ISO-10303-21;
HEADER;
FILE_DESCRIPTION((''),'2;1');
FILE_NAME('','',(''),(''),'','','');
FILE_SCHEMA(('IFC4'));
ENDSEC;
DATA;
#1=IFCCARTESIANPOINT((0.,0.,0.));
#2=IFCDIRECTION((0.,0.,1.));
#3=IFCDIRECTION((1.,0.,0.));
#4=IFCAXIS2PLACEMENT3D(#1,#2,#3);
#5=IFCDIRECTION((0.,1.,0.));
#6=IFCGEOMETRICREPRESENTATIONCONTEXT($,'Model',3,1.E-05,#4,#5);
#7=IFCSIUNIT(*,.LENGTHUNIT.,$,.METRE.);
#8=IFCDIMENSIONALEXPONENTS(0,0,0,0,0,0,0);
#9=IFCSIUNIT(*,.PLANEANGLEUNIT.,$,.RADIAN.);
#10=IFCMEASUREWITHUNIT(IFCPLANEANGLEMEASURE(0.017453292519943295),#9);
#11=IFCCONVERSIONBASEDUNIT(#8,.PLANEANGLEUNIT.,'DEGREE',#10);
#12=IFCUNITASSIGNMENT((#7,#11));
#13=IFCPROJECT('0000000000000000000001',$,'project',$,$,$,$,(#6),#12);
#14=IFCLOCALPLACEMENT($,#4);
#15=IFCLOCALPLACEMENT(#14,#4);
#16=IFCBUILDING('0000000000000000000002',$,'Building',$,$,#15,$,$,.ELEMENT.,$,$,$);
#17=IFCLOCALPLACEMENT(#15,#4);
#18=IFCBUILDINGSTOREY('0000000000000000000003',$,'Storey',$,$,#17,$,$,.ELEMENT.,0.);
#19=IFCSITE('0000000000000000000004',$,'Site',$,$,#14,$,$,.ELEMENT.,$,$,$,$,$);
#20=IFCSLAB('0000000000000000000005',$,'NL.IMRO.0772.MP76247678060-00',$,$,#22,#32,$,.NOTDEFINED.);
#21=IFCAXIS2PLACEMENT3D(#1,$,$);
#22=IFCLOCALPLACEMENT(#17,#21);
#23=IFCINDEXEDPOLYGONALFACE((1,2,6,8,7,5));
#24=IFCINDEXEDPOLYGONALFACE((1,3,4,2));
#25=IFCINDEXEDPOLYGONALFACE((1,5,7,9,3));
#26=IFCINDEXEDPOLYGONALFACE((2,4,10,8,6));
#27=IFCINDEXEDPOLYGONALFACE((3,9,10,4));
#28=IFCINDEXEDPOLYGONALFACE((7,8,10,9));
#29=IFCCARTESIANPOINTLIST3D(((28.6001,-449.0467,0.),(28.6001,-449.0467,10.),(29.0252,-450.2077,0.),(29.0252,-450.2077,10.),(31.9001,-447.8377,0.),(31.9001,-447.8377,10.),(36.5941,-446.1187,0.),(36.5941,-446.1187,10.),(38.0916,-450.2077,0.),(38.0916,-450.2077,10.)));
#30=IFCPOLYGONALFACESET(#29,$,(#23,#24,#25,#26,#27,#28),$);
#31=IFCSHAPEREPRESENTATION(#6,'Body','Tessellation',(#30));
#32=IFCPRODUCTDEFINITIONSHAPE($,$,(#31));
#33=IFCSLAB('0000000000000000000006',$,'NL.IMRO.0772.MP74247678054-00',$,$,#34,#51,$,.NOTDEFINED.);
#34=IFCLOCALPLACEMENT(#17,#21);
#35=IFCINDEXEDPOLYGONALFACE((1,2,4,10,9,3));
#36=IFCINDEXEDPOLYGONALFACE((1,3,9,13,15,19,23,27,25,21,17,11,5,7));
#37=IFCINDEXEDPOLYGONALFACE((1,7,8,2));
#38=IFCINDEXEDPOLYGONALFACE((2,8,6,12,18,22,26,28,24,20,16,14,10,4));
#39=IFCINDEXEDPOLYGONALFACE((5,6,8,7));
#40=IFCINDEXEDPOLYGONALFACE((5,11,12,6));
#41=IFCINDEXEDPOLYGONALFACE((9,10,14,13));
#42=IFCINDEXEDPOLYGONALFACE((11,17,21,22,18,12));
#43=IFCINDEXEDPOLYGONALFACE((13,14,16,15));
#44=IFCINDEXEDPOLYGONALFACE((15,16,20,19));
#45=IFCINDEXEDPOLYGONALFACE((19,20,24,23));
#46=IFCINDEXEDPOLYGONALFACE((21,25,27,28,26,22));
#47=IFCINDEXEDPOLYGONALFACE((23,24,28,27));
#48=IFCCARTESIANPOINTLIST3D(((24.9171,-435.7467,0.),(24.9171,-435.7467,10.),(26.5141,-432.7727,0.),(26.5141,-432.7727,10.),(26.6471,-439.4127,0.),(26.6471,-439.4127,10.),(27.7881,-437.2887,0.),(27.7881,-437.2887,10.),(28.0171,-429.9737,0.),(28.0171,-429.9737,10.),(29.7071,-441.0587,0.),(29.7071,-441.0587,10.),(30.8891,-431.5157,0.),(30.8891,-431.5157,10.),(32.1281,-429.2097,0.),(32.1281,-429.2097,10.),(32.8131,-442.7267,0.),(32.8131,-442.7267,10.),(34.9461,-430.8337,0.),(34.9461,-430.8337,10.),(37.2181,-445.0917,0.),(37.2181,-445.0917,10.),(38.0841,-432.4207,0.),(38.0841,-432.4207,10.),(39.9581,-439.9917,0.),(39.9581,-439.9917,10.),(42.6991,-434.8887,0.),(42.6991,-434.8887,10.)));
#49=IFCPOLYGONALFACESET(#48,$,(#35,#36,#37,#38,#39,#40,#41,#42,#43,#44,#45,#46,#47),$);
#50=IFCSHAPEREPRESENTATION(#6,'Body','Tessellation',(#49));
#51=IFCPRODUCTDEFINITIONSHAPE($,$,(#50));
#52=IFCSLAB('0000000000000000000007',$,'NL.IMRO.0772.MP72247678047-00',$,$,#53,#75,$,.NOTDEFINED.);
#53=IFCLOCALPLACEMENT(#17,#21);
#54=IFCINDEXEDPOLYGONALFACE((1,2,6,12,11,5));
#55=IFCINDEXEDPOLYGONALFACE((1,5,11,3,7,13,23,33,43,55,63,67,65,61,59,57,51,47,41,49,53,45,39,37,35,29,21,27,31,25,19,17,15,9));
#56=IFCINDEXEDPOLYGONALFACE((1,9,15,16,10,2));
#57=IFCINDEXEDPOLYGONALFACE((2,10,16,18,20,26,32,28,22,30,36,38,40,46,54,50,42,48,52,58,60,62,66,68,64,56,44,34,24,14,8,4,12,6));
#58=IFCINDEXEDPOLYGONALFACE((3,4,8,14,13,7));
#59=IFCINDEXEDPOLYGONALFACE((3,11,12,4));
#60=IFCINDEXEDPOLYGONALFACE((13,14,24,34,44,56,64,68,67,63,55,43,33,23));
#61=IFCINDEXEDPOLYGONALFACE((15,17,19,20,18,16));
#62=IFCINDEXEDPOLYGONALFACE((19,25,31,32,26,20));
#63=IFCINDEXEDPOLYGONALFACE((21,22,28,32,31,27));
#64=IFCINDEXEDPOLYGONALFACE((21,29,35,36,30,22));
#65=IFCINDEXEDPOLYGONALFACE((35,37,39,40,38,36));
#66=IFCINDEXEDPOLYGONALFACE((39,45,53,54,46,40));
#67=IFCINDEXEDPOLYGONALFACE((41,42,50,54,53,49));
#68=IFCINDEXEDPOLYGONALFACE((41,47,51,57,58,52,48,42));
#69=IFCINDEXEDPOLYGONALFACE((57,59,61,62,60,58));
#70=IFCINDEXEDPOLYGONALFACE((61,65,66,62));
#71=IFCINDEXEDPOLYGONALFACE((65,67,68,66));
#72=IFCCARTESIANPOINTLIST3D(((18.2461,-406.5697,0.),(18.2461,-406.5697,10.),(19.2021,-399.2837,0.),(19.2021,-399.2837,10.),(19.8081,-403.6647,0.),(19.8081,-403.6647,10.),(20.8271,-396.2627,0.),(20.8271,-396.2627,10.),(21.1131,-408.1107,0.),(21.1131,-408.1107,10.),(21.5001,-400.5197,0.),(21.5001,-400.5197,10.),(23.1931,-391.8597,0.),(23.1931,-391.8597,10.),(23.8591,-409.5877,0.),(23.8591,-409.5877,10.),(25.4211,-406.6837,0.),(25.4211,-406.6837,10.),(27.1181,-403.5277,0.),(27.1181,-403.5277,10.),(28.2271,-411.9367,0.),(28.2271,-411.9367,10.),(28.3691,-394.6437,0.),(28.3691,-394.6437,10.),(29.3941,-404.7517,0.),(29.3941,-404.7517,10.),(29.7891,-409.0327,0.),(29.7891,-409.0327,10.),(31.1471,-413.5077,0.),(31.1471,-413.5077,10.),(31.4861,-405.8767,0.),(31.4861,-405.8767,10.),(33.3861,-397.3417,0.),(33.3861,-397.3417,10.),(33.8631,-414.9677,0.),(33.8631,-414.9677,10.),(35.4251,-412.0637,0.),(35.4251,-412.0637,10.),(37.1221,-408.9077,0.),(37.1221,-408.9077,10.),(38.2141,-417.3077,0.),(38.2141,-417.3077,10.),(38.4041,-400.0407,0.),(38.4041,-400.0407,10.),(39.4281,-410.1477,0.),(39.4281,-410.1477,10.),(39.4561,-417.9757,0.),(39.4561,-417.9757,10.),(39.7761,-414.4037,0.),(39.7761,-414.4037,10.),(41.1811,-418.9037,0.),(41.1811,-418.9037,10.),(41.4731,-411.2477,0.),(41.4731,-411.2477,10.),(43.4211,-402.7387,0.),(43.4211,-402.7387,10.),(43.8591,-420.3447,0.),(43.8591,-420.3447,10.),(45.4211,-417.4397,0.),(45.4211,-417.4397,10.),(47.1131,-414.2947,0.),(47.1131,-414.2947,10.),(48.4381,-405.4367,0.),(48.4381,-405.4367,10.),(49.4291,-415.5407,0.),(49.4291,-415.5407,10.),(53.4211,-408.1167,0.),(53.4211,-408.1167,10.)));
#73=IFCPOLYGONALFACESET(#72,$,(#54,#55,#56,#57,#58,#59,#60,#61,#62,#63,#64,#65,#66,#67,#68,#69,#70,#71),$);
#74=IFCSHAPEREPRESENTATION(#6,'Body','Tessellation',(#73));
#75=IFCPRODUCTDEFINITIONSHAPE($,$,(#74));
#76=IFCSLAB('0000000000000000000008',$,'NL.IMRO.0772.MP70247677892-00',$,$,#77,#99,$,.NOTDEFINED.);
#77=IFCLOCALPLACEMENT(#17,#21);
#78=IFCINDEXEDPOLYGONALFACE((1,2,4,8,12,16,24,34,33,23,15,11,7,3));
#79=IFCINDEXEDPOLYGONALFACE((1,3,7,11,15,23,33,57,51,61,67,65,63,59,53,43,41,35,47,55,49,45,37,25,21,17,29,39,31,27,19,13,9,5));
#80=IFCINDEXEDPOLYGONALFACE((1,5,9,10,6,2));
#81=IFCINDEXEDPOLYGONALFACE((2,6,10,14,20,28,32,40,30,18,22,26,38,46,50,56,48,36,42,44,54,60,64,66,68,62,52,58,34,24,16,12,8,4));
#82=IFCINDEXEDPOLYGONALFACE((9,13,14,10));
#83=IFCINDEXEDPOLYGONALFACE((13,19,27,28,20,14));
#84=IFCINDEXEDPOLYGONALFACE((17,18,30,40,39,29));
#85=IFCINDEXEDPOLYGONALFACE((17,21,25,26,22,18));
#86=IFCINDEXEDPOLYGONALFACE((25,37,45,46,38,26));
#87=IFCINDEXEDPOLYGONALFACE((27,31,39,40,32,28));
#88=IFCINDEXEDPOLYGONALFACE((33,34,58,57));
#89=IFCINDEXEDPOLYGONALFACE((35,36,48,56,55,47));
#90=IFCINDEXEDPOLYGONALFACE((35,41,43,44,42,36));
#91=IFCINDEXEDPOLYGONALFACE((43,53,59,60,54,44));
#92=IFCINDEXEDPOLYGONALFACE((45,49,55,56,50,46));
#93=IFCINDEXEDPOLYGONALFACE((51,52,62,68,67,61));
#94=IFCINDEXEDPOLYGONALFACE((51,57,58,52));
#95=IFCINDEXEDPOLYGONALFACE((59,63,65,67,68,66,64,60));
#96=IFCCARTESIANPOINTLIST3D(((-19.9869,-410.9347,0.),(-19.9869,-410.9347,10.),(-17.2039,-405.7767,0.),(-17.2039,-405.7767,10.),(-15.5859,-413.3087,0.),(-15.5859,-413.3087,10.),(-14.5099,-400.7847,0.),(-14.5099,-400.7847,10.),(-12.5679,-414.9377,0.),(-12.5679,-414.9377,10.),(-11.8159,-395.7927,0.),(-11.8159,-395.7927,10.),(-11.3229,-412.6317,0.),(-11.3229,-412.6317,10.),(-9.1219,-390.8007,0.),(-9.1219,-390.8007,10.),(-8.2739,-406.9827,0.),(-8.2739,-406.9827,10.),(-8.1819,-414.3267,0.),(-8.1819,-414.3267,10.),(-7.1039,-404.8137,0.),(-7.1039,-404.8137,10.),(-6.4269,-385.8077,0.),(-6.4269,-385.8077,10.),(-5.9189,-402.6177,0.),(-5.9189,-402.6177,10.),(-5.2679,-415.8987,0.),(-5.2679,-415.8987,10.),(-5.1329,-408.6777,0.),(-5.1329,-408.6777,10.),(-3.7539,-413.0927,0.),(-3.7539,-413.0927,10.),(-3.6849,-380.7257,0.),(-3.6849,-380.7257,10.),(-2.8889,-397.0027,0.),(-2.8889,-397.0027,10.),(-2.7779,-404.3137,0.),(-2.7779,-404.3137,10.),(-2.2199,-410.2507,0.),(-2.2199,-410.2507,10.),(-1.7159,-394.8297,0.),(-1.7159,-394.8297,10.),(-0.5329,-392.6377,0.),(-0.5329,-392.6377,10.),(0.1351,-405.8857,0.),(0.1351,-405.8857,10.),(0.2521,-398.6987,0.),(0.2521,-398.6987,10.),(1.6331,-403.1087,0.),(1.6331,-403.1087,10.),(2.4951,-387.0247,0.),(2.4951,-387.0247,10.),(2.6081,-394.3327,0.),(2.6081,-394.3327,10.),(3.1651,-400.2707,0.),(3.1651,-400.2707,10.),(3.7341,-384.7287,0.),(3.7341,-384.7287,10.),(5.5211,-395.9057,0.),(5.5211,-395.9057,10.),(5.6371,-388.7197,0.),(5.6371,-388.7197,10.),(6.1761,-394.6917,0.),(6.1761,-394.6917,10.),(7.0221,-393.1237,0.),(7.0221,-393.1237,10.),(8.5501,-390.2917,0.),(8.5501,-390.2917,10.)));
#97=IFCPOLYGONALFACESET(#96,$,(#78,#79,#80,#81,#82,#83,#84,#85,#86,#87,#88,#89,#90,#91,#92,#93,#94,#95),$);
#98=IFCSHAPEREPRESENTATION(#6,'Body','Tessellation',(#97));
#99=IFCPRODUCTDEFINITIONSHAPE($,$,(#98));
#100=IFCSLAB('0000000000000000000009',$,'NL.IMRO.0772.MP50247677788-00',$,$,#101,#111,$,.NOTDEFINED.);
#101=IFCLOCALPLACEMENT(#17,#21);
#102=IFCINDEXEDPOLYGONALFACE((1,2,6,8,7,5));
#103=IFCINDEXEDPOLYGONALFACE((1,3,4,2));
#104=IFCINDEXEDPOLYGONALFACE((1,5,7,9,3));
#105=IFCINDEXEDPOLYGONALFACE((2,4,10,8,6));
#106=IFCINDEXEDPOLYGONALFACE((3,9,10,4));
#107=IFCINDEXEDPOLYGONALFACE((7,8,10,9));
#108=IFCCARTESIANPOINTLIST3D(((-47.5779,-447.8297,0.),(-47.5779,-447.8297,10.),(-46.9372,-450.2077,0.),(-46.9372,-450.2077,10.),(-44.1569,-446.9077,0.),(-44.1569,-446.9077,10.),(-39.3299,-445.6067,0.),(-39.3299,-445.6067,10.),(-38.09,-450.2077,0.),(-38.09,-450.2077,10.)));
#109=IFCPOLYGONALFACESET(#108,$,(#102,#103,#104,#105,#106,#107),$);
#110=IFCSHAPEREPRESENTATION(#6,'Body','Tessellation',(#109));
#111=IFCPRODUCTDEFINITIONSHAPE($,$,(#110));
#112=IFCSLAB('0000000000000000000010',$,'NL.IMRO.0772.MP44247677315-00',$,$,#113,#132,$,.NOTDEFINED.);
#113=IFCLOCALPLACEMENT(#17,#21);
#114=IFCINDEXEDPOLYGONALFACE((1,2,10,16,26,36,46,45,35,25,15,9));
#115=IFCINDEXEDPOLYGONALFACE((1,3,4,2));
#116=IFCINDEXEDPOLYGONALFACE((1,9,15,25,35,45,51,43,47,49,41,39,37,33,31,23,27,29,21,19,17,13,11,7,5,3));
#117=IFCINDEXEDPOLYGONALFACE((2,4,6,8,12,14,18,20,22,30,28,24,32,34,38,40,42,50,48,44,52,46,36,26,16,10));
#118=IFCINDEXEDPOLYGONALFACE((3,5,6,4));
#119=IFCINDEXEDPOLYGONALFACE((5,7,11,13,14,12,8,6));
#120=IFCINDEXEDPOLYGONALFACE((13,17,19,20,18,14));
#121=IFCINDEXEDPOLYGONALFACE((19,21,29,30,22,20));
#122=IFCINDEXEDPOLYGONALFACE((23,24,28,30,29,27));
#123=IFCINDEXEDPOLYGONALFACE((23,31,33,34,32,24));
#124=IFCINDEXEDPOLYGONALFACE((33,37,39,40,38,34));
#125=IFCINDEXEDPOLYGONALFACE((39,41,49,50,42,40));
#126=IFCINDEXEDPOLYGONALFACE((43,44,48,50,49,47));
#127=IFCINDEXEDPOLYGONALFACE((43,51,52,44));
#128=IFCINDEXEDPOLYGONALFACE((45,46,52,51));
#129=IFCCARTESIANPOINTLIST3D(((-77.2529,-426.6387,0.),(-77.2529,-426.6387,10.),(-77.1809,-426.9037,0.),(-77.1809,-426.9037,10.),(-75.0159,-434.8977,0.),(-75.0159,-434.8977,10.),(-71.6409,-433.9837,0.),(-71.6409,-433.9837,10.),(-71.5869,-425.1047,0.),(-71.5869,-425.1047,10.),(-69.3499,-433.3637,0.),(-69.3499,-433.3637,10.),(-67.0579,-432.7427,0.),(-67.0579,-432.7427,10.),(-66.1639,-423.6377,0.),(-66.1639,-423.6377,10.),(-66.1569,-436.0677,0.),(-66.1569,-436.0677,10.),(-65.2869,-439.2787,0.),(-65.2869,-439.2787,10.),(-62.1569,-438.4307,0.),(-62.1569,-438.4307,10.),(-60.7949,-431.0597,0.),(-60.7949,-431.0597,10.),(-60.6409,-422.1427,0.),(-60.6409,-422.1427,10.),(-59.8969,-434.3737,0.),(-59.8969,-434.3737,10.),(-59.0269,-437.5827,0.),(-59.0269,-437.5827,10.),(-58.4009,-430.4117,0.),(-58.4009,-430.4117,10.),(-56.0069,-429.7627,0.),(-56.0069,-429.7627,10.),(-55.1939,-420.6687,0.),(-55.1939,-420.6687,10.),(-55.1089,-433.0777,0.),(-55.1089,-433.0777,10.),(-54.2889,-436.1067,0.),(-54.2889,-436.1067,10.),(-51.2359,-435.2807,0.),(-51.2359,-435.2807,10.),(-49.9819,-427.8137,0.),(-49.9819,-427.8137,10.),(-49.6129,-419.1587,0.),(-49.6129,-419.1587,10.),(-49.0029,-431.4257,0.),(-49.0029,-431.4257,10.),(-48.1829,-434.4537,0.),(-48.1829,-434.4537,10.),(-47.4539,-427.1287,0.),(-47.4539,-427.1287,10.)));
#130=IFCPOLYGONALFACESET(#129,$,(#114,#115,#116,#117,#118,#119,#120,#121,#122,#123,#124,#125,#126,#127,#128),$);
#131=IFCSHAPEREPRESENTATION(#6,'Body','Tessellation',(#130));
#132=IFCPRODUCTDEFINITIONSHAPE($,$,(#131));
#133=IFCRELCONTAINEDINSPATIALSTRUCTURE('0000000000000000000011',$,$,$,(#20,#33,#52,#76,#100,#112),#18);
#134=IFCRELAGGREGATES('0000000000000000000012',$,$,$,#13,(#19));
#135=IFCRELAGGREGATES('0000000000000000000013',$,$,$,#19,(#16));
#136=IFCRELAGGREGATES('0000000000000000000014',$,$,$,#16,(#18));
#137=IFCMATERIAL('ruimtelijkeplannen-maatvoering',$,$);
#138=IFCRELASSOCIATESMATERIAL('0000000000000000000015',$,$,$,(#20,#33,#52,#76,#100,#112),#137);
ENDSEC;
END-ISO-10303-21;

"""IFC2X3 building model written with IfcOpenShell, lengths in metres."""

from ifc_helpers import new_model, entity, si_unit, converted_unit, direction, origin_with_axes, place, context, project, spatial, polyline, outline, extrude, material, element, save


model = new_model("IFC2X3")

# Units and contexts
model_context = context("Model", 3, precision=1e-05, world=origin_with_axes(), true_north=direction((0.0, 1.0, 0.0)))
ifc_project = project(units=[si_unit("LENGTHUNIT", "METRE"), converted_unit("PLANEANGLEUNIT", "DEGREE", entity("IfcPlaneAngleMeasure", 0.017453292519943295), si_unit("PLANEANGLEUNIT", "RADIAN"), dimensions=[0, 0, 0, 0, 0, 0, 0])], contexts=[model_context])

# Site, building, storey
site_placement = place(None, origin_with_axes())
site = spatial("IfcSite", under=ifc_project, at=site_placement, Name="Site", CompositionType="ELEMENT")
building_placement = place(site_placement, origin_with_axes())
building = spatial("IfcBuilding", under=site, at=building_placement, Name="Building", CompositionType="ELEMENT")
storey_placement = place(building_placement, origin_with_axes())
storey = spatial("IfcBuildingStorey", under=building, at=storey_placement, Name="Storey", CompositionType="ELEMENT", Elevation=0.0)

# Slabs
ifc_material = material(Name="ruimtelijkeplannen-maatvoering")
slab_1_placement = place(storey_placement, origin_with_axes())
element("IfcSlab", 1, at=slab_1_placement, inside=storey, material=ifc_material, Name="NL.IMRO.0772.MP76247678060-00", PredefinedType="NOTDEFINED", context=model_context, shape_type="SweptSolid", body=[
    extrude(outline(polyline([(28.6001, -449.0467), (31.9001, -447.8377), (36.5941, -446.1187), (38.0916, -450.2077), (29.0252, -450.2077), (28.6001, -449.0467)])), origin_with_axes(), (0.0, 0.0, 1.0), 10.0),
])
slab_2_placement = place(storey_placement, origin_with_axes())
element("IfcSlab", 2, at=slab_2_placement, inside=storey, material=ifc_material, Name="NL.IMRO.0772.MP74247678054-00", PredefinedType="NOTDEFINED", context=model_context, shape_type="SweptSolid", body=[
    extrude(outline(polyline([(24.9171, -435.7467), (26.5141, -432.7727), (28.0171, -429.9737), (30.8891, -431.5157), (32.1281, -429.2097), (34.9461, -430.8337), (38.0841, -432.4207), (42.6991, -434.8887), (39.9581, -439.9917), (37.2181, -445.0917), (32.8131, -442.7267), (29.7071, -441.0587), (26.6471, -439.4127), (27.7881, -437.2887), (24.9171, -435.7467)])), origin_with_axes(), (0.0, 0.0, 1.0), 10.0),
])
slab_3_placement = place(storey_placement, origin_with_axes())
element("IfcSlab", 3, at=slab_3_placement, inside=storey, material=ifc_material, Name="NL.IMRO.0772.MP72247678047-00", PredefinedType="NOTDEFINED", context=model_context, shape_type="SweptSolid", body=[
    extrude(outline(polyline([(43.4211, -402.7387), (48.4381, -405.4367), (53.4211, -408.1167), (49.4291, -415.5407), (47.1131, -414.2947), (45.4211, -417.4397), (43.8591, -420.3447), (41.1811, -418.9037), (39.4561, -417.9757), (38.2141, -417.3077), (39.7761, -414.4037), (41.4731, -411.2477), (39.4281, -410.1477), (37.1221, -408.9077), (35.4251, -412.0637), (33.8631, -414.9677), (31.1471, -413.5077), (28.2271, -411.9367), (29.7891, -409.0327), (31.4861, -405.8767), (29.3941, -404.7517), (27.1181, -403.5277), (25.4211, -406.6837), (23.8591, -409.5877), (21.1131, -408.1107), (18.2461, -406.5697), (19.8081, -403.6647), (21.5001, -400.5197), (19.2021, -399.2837), (20.8271, -396.2627), (23.1931, -391.8597), (28.3691, -394.6437), (33.3861, -397.3417), (38.4041, -400.0407), (43.4211, -402.7387)])), origin_with_axes(), (0.0, 0.0, 1.0), 10.0),
])
slab_4_placement = place(storey_placement, origin_with_axes())
element("IfcSlab", 4, at=slab_4_placement, inside=storey, material=ifc_material, Name="NL.IMRO.0772.MP70247677892-00", PredefinedType="NOTDEFINED", context=model_context, shape_type="SweptSolid", body=[
    extrude(outline(polyline([(-15.5859, -413.3087), (-19.9869, -410.9347), (-17.2039, -405.7767), (-14.5099, -400.7847), (-11.8159, -395.7927), (-9.1219, -390.8007), (-6.4269, -385.8077), (-3.6849, -380.7257), (3.7341, -384.7287), (2.4951, -387.0247), (5.6371, -388.7197), (8.5501, -390.2917), (7.0221, -393.1237), (6.1761, -394.6917), (5.5211, -395.9057), (2.6081, -394.3327), (-0.5329, -392.6377), (-1.7159, -394.8297), (-2.8889, -397.0027), (0.2521, -398.6987), (3.1651, -400.2707), (1.6331, -403.1087), (0.1351, -405.8857), (-2.7779, -404.3137), (-5.9189, -402.6177), (-7.1039, -404.8137), (-8.2739, -406.9827), (-5.1329, -408.6777), (-2.2199, -410.2507), (-3.7539, -413.0927), (-5.2679, -415.8987), (-8.1819, -414.3267), (-11.3229, -412.6317), (-12.5679, -414.9377), (-15.5859, -413.3087)])), origin_with_axes(), (0.0, 0.0, 1.0), 10.0),
])
slab_5_placement = place(storey_placement, origin_with_axes())
element("IfcSlab", 5, at=slab_5_placement, inside=storey, material=ifc_material, Name="NL.IMRO.0772.MP50247677788-00", PredefinedType="NOTDEFINED", context=model_context, shape_type="SweptSolid", body=[
    extrude(outline(polyline([(-47.5779, -447.8297), (-44.1569, -446.9077), (-39.3299, -445.6067), (-38.09, -450.2077), (-46.9372, -450.2077), (-47.5779, -447.8297)])), origin_with_axes(), (0.0, 0.0, 1.0), 10.0),
])
slab_6_placement = place(storey_placement, origin_with_axes())
element("IfcSlab", 6, at=slab_6_placement, inside=storey, material=ifc_material, Name="NL.IMRO.0772.MP44247677315-00", PredefinedType="NOTDEFINED", context=model_context, shape_type="SweptSolid", body=[
    extrude(outline(polyline([(-75.0159, -434.8977), (-77.1809, -426.9037), (-77.2529, -426.6387), (-71.5869, -425.1047), (-66.1639, -423.6377), (-60.6409, -422.1427), (-55.1939, -420.6687), (-49.6129, -419.1587), (-47.4539, -427.1287), (-49.9819, -427.8137), (-49.0029, -431.4257), (-48.1829, -434.4537), (-51.2359, -435.2807), (-54.2889, -436.1067), (-55.1089, -433.0777), (-56.0069, -429.7627), (-58.4009, -430.4117), (-60.7949, -431.0597), (-59.8969, -434.3737), (-59.0269, -437.5827), (-62.1569, -438.4307), (-65.2869, -439.2787), (-66.1569, -436.0677), (-67.0579, -432.7427), (-69.3499, -433.3637), (-71.6409, -433.9837), (-75.0159, -434.8977)])), origin_with_axes(), (0.0, 0.0, 1.0), 10.0),
])

save(model, "model.ifc")
